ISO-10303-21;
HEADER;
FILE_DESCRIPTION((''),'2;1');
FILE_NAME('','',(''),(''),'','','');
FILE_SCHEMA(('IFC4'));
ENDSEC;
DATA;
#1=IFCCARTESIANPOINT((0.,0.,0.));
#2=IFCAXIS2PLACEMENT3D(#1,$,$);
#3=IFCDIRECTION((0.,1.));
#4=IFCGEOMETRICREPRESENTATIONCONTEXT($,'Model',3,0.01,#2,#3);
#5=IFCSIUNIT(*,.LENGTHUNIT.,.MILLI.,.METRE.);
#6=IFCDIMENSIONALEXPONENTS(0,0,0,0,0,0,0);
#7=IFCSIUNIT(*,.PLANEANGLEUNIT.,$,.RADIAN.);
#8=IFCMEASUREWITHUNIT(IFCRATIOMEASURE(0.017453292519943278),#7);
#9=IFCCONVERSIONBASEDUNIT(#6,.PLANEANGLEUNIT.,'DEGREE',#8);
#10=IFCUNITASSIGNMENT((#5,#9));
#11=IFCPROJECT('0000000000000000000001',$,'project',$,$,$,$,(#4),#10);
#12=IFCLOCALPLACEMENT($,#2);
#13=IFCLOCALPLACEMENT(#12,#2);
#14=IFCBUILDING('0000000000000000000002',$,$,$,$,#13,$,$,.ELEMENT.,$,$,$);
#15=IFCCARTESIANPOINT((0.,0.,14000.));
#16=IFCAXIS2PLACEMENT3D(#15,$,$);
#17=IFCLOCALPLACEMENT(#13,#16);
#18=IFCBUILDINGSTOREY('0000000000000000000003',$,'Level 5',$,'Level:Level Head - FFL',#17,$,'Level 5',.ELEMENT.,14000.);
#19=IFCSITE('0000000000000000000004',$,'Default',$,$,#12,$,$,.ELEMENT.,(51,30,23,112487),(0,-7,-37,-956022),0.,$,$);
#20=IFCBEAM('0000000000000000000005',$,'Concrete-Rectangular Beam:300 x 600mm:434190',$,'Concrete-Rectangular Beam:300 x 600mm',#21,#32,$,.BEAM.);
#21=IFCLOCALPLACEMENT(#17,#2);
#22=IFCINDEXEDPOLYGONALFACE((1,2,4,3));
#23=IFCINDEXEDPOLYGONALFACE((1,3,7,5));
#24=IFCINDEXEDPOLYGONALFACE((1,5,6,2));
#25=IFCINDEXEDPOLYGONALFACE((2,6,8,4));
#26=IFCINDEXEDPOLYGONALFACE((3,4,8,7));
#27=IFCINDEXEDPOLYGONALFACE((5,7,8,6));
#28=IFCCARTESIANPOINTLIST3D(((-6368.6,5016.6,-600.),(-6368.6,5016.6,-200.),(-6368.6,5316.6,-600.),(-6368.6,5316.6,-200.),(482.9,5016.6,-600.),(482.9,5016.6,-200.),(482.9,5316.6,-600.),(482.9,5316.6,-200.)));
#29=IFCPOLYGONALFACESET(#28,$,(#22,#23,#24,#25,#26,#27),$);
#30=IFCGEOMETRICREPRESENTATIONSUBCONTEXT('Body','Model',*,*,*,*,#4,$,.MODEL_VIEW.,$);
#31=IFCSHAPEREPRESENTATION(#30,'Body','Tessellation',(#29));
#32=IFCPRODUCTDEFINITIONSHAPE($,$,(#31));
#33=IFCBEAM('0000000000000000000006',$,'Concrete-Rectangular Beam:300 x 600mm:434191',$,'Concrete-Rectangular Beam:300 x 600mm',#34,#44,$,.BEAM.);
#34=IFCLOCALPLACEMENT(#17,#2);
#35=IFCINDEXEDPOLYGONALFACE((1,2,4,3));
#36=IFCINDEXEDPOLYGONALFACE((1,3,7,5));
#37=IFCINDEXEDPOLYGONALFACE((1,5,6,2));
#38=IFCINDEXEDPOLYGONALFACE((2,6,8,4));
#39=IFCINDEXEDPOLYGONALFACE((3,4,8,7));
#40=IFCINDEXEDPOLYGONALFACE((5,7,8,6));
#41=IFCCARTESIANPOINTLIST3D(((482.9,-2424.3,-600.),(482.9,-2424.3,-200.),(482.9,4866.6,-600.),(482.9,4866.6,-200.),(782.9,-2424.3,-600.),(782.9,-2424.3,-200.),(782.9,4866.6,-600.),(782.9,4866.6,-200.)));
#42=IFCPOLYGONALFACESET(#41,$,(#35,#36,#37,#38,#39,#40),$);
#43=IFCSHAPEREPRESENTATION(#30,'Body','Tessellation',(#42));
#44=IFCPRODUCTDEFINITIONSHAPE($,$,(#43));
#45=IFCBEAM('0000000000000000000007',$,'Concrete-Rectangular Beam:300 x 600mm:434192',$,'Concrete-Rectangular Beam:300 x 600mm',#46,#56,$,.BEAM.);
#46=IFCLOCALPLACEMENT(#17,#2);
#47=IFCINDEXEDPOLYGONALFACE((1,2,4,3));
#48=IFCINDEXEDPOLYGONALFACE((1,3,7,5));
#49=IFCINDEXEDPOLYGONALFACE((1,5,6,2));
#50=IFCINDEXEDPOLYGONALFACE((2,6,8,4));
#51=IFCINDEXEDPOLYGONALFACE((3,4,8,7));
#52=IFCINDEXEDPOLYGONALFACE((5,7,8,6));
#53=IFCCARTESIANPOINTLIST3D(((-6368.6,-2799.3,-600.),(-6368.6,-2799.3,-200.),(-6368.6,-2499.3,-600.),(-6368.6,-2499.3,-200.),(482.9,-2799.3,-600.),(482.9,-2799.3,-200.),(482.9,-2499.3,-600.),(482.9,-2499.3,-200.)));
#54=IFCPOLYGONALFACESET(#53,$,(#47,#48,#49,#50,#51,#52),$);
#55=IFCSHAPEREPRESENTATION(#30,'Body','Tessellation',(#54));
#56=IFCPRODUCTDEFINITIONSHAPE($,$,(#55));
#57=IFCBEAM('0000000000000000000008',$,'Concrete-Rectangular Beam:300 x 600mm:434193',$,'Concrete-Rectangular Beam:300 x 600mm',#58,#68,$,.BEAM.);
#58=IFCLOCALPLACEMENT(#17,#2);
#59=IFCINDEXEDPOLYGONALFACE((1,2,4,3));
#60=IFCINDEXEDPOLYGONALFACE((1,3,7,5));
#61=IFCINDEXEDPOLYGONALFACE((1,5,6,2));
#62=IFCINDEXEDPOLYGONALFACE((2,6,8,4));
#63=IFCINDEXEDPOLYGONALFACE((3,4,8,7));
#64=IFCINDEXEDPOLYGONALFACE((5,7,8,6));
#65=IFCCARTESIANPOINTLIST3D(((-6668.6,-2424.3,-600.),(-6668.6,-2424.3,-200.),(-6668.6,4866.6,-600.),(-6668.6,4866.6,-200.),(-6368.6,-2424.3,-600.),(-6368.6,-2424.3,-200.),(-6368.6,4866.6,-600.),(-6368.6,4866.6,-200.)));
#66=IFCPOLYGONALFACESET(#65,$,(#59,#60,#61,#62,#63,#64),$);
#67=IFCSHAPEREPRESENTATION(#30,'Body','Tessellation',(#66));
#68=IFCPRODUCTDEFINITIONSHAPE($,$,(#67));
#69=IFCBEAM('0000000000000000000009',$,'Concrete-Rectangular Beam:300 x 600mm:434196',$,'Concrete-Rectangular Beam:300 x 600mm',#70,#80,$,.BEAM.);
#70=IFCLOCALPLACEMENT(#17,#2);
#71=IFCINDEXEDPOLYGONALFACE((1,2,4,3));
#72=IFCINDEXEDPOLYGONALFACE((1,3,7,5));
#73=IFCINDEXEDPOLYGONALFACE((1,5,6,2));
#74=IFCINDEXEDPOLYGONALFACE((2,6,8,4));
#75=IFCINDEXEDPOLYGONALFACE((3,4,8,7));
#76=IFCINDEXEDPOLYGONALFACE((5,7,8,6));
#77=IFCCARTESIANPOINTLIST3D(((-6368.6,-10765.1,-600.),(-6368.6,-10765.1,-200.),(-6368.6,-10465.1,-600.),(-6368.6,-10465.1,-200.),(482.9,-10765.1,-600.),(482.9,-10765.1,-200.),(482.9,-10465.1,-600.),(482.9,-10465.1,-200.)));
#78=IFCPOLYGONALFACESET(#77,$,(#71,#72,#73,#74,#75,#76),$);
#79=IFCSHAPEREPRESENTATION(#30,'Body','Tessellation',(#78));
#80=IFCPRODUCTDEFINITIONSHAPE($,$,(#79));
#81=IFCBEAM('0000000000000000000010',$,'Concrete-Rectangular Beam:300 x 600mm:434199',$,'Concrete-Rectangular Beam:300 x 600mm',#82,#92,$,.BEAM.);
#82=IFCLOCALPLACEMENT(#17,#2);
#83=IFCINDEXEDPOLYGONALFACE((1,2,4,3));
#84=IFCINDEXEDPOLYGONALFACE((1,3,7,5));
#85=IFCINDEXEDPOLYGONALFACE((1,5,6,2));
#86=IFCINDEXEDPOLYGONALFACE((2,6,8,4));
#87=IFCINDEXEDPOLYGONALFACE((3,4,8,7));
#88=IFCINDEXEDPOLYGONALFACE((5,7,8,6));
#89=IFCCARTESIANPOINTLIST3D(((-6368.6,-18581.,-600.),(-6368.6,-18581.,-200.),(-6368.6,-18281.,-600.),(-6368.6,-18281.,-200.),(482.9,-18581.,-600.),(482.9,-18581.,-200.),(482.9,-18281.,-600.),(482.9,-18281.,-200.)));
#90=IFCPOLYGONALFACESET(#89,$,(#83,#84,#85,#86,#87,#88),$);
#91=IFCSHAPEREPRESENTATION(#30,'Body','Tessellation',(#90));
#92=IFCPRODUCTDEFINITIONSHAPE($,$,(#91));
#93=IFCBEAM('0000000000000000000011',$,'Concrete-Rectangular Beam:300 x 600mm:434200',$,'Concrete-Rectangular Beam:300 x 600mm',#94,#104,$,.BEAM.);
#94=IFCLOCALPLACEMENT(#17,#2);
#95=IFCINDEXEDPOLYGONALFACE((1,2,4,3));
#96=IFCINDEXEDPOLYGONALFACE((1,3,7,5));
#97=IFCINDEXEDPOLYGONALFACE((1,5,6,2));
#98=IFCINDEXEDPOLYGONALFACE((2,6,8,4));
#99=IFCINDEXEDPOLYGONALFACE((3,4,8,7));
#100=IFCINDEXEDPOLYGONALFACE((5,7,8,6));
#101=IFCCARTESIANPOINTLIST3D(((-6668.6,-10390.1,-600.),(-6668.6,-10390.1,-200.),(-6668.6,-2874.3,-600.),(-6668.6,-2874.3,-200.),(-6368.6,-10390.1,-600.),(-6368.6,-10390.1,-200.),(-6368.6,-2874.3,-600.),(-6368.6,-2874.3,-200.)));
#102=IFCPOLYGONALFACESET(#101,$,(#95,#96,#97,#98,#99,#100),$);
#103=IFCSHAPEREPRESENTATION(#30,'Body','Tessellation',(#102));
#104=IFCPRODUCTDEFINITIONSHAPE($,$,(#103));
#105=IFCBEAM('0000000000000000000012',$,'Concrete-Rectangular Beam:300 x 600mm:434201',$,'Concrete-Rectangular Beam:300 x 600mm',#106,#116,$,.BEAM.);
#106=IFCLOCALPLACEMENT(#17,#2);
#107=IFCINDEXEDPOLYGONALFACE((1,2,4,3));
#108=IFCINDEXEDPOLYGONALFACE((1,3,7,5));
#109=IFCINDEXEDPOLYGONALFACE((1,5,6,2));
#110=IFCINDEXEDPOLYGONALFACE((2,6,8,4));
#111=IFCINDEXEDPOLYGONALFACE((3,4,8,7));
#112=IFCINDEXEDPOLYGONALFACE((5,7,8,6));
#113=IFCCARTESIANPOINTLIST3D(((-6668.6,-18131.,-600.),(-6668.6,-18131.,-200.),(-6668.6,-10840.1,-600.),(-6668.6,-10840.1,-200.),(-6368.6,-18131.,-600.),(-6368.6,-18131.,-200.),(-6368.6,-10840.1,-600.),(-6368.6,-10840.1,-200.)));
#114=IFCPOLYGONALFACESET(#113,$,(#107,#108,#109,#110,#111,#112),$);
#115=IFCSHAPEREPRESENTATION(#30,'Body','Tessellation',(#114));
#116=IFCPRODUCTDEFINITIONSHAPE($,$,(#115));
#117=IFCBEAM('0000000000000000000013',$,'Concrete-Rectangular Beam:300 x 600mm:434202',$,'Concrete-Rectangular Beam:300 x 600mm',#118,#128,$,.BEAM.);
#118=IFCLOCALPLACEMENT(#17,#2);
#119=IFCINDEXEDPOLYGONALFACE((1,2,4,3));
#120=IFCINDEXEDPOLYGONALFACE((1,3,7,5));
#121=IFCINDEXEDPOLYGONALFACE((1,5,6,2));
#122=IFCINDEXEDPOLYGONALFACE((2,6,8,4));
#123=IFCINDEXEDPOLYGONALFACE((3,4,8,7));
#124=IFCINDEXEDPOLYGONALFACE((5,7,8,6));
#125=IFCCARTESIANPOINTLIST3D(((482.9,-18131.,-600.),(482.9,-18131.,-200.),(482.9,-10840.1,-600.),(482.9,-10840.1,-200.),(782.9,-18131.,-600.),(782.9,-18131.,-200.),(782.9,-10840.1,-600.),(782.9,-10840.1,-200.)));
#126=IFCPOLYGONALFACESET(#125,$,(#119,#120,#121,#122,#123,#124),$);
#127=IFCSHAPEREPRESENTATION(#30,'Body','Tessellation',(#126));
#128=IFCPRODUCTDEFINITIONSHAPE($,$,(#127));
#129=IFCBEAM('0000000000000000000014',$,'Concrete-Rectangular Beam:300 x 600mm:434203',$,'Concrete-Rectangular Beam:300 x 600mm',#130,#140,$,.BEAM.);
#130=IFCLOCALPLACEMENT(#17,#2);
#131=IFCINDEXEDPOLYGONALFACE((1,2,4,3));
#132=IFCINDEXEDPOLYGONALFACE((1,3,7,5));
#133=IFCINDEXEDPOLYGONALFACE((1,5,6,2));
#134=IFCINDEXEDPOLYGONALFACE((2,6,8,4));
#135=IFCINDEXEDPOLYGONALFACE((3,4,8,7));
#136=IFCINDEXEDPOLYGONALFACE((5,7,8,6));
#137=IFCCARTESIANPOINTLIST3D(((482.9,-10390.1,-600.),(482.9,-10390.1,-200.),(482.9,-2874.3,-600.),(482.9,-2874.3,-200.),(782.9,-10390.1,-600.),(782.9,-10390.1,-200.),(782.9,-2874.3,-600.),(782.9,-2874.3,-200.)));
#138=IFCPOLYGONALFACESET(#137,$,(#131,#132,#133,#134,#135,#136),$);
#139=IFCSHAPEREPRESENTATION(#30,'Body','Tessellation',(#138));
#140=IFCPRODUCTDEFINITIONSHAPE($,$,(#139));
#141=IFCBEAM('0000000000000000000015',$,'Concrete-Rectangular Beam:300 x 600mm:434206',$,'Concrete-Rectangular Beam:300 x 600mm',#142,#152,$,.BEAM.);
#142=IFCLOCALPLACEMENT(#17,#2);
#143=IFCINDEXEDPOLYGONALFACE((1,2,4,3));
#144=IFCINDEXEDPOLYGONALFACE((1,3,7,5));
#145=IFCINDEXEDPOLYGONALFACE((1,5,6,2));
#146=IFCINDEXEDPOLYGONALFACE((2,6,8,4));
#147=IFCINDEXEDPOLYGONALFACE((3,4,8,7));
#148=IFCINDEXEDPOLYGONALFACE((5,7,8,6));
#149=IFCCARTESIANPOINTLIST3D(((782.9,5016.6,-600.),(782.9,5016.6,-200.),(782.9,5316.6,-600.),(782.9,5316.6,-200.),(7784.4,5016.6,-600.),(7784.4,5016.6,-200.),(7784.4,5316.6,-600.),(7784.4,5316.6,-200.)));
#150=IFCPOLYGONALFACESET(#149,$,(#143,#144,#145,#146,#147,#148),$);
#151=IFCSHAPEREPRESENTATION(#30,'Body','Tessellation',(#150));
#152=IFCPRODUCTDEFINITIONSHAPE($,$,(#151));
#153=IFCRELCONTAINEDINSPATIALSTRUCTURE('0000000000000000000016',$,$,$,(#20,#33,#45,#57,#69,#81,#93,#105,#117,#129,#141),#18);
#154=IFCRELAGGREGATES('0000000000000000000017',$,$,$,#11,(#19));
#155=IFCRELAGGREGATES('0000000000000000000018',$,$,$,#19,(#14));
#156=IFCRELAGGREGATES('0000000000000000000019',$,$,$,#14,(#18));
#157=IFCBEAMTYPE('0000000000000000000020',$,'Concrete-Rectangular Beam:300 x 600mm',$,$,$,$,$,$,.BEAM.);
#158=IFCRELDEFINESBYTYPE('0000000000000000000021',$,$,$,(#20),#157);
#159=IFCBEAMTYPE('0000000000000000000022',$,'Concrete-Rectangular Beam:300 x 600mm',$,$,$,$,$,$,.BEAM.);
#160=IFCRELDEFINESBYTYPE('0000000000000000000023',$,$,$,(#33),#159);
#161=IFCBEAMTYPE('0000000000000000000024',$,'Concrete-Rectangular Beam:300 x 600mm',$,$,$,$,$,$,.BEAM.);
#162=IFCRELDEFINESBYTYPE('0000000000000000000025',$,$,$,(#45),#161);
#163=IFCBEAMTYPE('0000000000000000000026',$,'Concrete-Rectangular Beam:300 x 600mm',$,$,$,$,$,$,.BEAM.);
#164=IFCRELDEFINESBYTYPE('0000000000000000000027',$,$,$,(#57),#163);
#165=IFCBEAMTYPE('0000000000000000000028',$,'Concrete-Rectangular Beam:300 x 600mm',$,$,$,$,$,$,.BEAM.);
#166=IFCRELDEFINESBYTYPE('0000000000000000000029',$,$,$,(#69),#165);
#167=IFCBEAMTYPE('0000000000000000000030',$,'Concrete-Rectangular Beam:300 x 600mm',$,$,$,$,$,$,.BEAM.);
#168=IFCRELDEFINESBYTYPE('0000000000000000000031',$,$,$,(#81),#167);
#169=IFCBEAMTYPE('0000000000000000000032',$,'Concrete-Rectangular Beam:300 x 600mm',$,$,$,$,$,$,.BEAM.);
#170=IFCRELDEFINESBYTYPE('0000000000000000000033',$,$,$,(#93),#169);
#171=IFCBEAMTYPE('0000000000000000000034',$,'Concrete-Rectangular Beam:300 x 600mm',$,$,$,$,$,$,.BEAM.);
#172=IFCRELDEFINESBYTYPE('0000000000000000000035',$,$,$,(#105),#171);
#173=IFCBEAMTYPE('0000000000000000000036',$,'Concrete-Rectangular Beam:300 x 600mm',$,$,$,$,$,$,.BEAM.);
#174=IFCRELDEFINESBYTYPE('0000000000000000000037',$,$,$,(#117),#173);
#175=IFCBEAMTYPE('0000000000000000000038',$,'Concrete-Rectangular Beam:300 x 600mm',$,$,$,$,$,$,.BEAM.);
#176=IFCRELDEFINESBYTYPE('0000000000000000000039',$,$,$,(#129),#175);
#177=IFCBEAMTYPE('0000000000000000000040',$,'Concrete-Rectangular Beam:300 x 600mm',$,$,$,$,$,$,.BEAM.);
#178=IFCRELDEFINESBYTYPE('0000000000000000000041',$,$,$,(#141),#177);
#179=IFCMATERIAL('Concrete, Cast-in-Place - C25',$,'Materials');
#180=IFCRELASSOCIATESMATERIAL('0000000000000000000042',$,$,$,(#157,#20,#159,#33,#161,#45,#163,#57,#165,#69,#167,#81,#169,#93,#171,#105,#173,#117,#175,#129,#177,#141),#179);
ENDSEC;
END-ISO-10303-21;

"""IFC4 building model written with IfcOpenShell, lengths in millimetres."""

from ifc_helpers import new_model, entity, si_unit, converted_unit, direction, frame, origin, place, context, subcontext, project, spatial, indexed_curve, outline, extrude, source, transform, mapped, material, type_object, type_shapes, element, save


model = new_model("IFC4")

# Units and contexts
model_context = context("Model", 3, precision=0.01, world=origin(), true_north=direction((0.0, 1.0)))
body_context = subcontext(model_context, "Body", "Model", "MODEL_VIEW")
ifc_project = project(units=[si_unit("LENGTHUNIT", "METRE", prefix="MILLI"), converted_unit("PLANEANGLEUNIT", "DEGREE", entity("IfcRatioMeasure", 0.017453292519943278), si_unit("PLANEANGLEUNIT", "RADIAN"), dimensions=[0, 0, 0, 0, 0, 0, 0])], contexts=[model_context])

# Site, building, storey
site_placement = place(None, origin())
site = spatial("IfcSite", under=ifc_project, at=site_placement, Name="Default", CompositionType="ELEMENT", RefLatitude=(51, 30, 23, 112487), RefLongitude=(0, -7, -37, -956022), RefElevation=0.0)
building_placement = place(site_placement, origin())
building = spatial("IfcBuilding", under=site, at=building_placement, CompositionType="ELEMENT")
storey_placement = place(building_placement, frame((0.0, 0.0, 14000.0)))
storey = spatial("IfcBuildingStorey", under=building, at=storey_placement, Name="Level 5", ObjectType="Level:Level Head - FFL", LongName="Level 5", CompositionType="ELEMENT", Elevation=14000.0)

# Beams
ifc_material = material(Name="Concrete, Cast-in-Place - C25", Category="Materials")
beam_type_1 = type_object("IfcBeamType", Name="Concrete-Rectangular Beam:300 x 600mm", PredefinedType="BEAM", material=ifc_material)
shared_shape_1 = source(origin(), body_context, "Body", "SweptSolid", [
    extrude(outline(indexed_curve([(-200.0, -150.0), (200.0, -150.0), (200.0, 150.0), (-200.0, 150.0), (-200.0, -150.0)], self_intersect=False)), frame((-6368.6, 5166.6, 13600.0), z_axis=(1.0, 0.0, 0.0), x_axis=(0.0, 0.0, -1.0)), (0.0, 0.0, 1.0), 6851.5),
])
type_shapes(beam_type_1, [shared_shape_1])
beam_1_placement = place(storey_placement, frame((0.0, 0.0, -14000.0)))
element("IfcBeam", 1, at=beam_1_placement, inside=storey, type_object=beam_type_1, material=ifc_material, Name="Concrete-Rectangular Beam:300 x 600mm:434190", ObjectType="Concrete-Rectangular Beam:300 x 600mm", PredefinedType="BEAM", context=body_context, shape_type="MappedRepresentation", body=[
    mapped(shared_shape_1, transform((0.0, 0.0, 0.0), scale=1.0)),
])
beam_type_2 = type_object("IfcBeamType", Name="Concrete-Rectangular Beam:300 x 600mm", PredefinedType="BEAM", material=ifc_material)
shared_shape_2 = source(origin(), body_context, "Body", "SweptSolid", [
    extrude(outline(indexed_curve([(-150.0, -200.0), (150.0, -200.0), (150.0, 200.0), (-150.0, 200.0), (-150.0, -200.0)], self_intersect=False)), frame((632.9, 4866.6, 13600.0), z_axis=(0.0, -1.0, 0.0), x_axis=(-1.0, 0.0, 0.0)), (0.0, 0.0, 1.0), 7290.9),
])
type_shapes(beam_type_2, [shared_shape_2])
beam_2_placement = place(storey_placement, frame((0.0, 0.0, -14000.0)))
element("IfcBeam", 2, at=beam_2_placement, inside=storey, type_object=beam_type_2, material=ifc_material, Name="Concrete-Rectangular Beam:300 x 600mm:434191", ObjectType="Concrete-Rectangular Beam:300 x 600mm", PredefinedType="BEAM", context=body_context, shape_type="MappedRepresentation", body=[
    mapped(shared_shape_2, transform((0.0, 0.0, 0.0), scale=1.0)),
])
beam_type_3 = type_object("IfcBeamType", Name="Concrete-Rectangular Beam:300 x 600mm", PredefinedType="BEAM", material=ifc_material)
shared_shape_3 = source(origin(), body_context, "Body", "SweptSolid", [
    extrude(outline(indexed_curve([(-200.0, -150.0), (200.0, -150.0), (200.0, 150.0), (-200.0, 150.0), (-200.0, -150.0)], self_intersect=False)), frame((482.9, -2649.3, 13600.0), z_axis=(-1.0, 0.0, 0.0), x_axis=(0.0, 0.0, -1.0)), (0.0, 0.0, 1.0), 6851.5),
])
type_shapes(beam_type_3, [shared_shape_3])
beam_3_placement = place(storey_placement, frame((0.0, 0.0, -14000.0)))
element("IfcBeam", 3, at=beam_3_placement, inside=storey, type_object=beam_type_3, material=ifc_material, Name="Concrete-Rectangular Beam:300 x 600mm:434192", ObjectType="Concrete-Rectangular Beam:300 x 600mm", PredefinedType="BEAM", context=body_context, shape_type="MappedRepresentation", body=[
    mapped(shared_shape_3, transform((0.0, 0.0, 0.0), scale=1.0)),
])
beam_type_4 = type_object("IfcBeamType", Name="Concrete-Rectangular Beam:300 x 600mm", PredefinedType="BEAM", material=ifc_material)
shared_shape_4 = source(origin(), body_context, "Body", "SweptSolid", [
    extrude(outline(indexed_curve([(-150.0, -200.0), (150.0, -200.0), (150.0, 200.0), (-150.0, 200.0), (-150.0, -200.0)], self_intersect=False)), frame((-6518.6, -2424.3, 13600.0), z_axis=(0.0, 1.0, 0.0), x_axis=(-1.0, 0.0, 0.0)), (0.0, 0.0, 1.0), 7290.9),
])
type_shapes(beam_type_4, [shared_shape_4])
beam_4_placement = place(storey_placement, frame((0.0, 0.0, -14000.0)))
element("IfcBeam", 4, at=beam_4_placement, inside=storey, type_object=beam_type_4, material=ifc_material, Name="Concrete-Rectangular Beam:300 x 600mm:434193", ObjectType="Concrete-Rectangular Beam:300 x 600mm", PredefinedType="BEAM", context=body_context, shape_type="MappedRepresentation", body=[
    mapped(shared_shape_4, transform((0.0, 0.0, 0.0), scale=1.0)),
])
beam_type_5 = type_object("IfcBeamType", Name="Concrete-Rectangular Beam:300 x 600mm", PredefinedType="BEAM", material=ifc_material)
shared_shape_5 = source(origin(), body_context, "Body", "SweptSolid", [
    extrude(outline(indexed_curve([(-200.0, -150.0), (200.0, -150.0), (200.0, 150.0), (-200.0, 150.0), (-200.0, -150.0)], self_intersect=False)), frame((482.9, -10615.1, 13600.0), z_axis=(-1.0, 0.0, 0.0), x_axis=(0.0, 0.0, -1.0)), (0.0, 0.0, 1.0), 6851.5),
])
type_shapes(beam_type_5, [shared_shape_5])
beam_5_placement = place(storey_placement, frame((0.0, 0.0, -14000.0)))
element("IfcBeam", 5, at=beam_5_placement, inside=storey, type_object=beam_type_5, material=ifc_material, Name="Concrete-Rectangular Beam:300 x 600mm:434196", ObjectType="Concrete-Rectangular Beam:300 x 600mm", PredefinedType="BEAM", context=body_context, shape_type="MappedRepresentation", body=[
    mapped(shared_shape_5, transform((0.0, 0.0, 0.0), scale=1.0)),
])
beam_type_6 = type_object("IfcBeamType", Name="Concrete-Rectangular Beam:300 x 600mm", PredefinedType="BEAM", material=ifc_material)
shared_shape_6 = source(origin(), body_context, "Body", "SweptSolid", [
    extrude(outline(indexed_curve([(-200.0, -150.0), (200.0, -150.0), (200.0, 150.0), (-200.0, 150.0), (-200.0, -150.0)], self_intersect=False)), frame((482.9, -18431.0, 13600.0), z_axis=(-1.0, 0.0, 0.0), x_axis=(0.0, 0.0, -1.0)), (0.0, 0.0, 1.0), 6851.5),
])
type_shapes(beam_type_6, [shared_shape_6])
beam_6_placement = place(storey_placement, frame((0.0, 0.0, -14000.0)))
element("IfcBeam", 6, at=beam_6_placement, inside=storey, type_object=beam_type_6, material=ifc_material, Name="Concrete-Rectangular Beam:300 x 600mm:434199", ObjectType="Concrete-Rectangular Beam:300 x 600mm", PredefinedType="BEAM", context=body_context, shape_type="MappedRepresentation", body=[
    mapped(shared_shape_6, transform((0.0, 0.0, 0.0), scale=1.0)),
])
beam_type_7 = type_object("IfcBeamType", Name="Concrete-Rectangular Beam:300 x 600mm", PredefinedType="BEAM", material=ifc_material)
shared_shape_7 = source(origin(), body_context, "Body", "SweptSolid", [
    extrude(outline(indexed_curve([(-150.0, -200.0), (150.0, -200.0), (150.0, 200.0), (-150.0, 200.0), (-150.0, -200.0)], self_intersect=False)), frame((-6518.6, -2874.3, 13600.0), z_axis=(0.0, -1.0, 0.0), x_axis=(-1.0, 0.0, 0.0)), (0.0, 0.0, 1.0), 7515.9),
])
type_shapes(beam_type_7, [shared_shape_7])
beam_7_placement = place(storey_placement, frame((0.0, 0.0, -14000.0)))
element("IfcBeam", 7, at=beam_7_placement, inside=storey, type_object=beam_type_7, material=ifc_material, Name="Concrete-Rectangular Beam:300 x 600mm:434200", ObjectType="Concrete-Rectangular Beam:300 x 600mm", PredefinedType="BEAM", context=body_context, shape_type="MappedRepresentation", body=[
    mapped(shared_shape_7, transform((0.0, 0.0, 0.0), scale=1.0)),
])
beam_type_8 = type_object("IfcBeamType", Name="Concrete-Rectangular Beam:300 x 600mm", PredefinedType="BEAM", material=ifc_material)
shared_shape_8 = source(origin(), body_context, "Body", "SweptSolid", [
    extrude(outline(indexed_curve([(-150.0, -200.0), (150.0, -200.0), (150.0, 200.0), (-150.0, 200.0), (-150.0, -200.0)], self_intersect=False)), frame((-6518.6, -10840.1, 13600.0), z_axis=(0.0, -1.0, 0.0), x_axis=(-1.0, 0.0, 0.0)), (0.0, 0.0, 1.0), 7290.9),
])
type_shapes(beam_type_8, [shared_shape_8])
beam_8_placement = place(storey_placement, frame((0.0, 0.0, -14000.0)))
element("IfcBeam", 8, at=beam_8_placement, inside=storey, type_object=beam_type_8, material=ifc_material, Name="Concrete-Rectangular Beam:300 x 600mm:434201", ObjectType="Concrete-Rectangular Beam:300 x 600mm", PredefinedType="BEAM", context=body_context, shape_type="MappedRepresentation", body=[
    mapped(shared_shape_8, transform((0.0, 0.0, 0.0), scale=1.0)),
])
beam_type_9 = type_object("IfcBeamType", Name="Concrete-Rectangular Beam:300 x 600mm", PredefinedType="BEAM", material=ifc_material)
shared_shape_9 = source(origin(), body_context, "Body", "SweptSolid", [
    extrude(outline(indexed_curve([(-150.0, -200.0), (150.0, -200.0), (150.0, 200.0), (-150.0, 200.0), (-150.0, -200.0)], self_intersect=False)), frame((632.9, -18131.0, 13600.0), z_axis=(0.0, 1.0, 0.0), x_axis=(-1.0, 0.0, 0.0)), (0.0, 0.0, 1.0), 7290.9),
])
type_shapes(beam_type_9, [shared_shape_9])
beam_9_placement = place(storey_placement, frame((0.0, 0.0, -14000.0)))
element("IfcBeam", 9, at=beam_9_placement, inside=storey, type_object=beam_type_9, material=ifc_material, Name="Concrete-Rectangular Beam:300 x 600mm:434202", ObjectType="Concrete-Rectangular Beam:300 x 600mm", PredefinedType="BEAM", context=body_context, shape_type="MappedRepresentation", body=[
    mapped(shared_shape_9, transform((0.0, 0.0, 0.0), scale=1.0)),
])
beam_type_10 = type_object("IfcBeamType", Name="Concrete-Rectangular Beam:300 x 600mm", PredefinedType="BEAM", material=ifc_material)
shared_shape_10 = source(origin(), body_context, "Body", "SweptSolid", [
    extrude(outline(indexed_curve([(-150.0, -200.0), (150.0, -200.0), (150.0, 200.0), (-150.0, 200.0), (-150.0, -200.0)], self_intersect=False)), frame((632.9, -10390.1, 13600.0), z_axis=(0.0, 1.0, 0.0), x_axis=(-1.0, 0.0, 0.0)), (0.0, 0.0, 1.0), 7515.9),
])
type_shapes(beam_type_10, [shared_shape_10])
beam_10_placement = place(storey_placement, frame((0.0, 0.0, -14000.0)))
element("IfcBeam", 10, at=beam_10_placement, inside=storey, type_object=beam_type_10, material=ifc_material, Name="Concrete-Rectangular Beam:300 x 600mm:434203", ObjectType="Concrete-Rectangular Beam:300 x 600mm", PredefinedType="BEAM", context=body_context, shape_type="MappedRepresentation", body=[
    mapped(shared_shape_10, transform((0.0, 0.0, 0.0), scale=1.0)),
])
beam_type_11 = type_object("IfcBeamType", Name="Concrete-Rectangular Beam:300 x 600mm", PredefinedType="BEAM", material=ifc_material)
shared_shape_11 = source(origin(), body_context, "Body", "SweptSolid", [
    extrude(outline(indexed_curve([(-200.0, -150.0), (200.0, -150.0), (200.0, 150.0), (-200.0, 150.0), (-200.0, -150.0)], self_intersect=False)), frame((782.9, 5166.6, 13600.0), z_axis=(1.0, 0.0, 0.0), x_axis=(0.0, 0.0, -1.0)), (0.0, 0.0, 1.0), 7001.5),
])
type_shapes(beam_type_11, [shared_shape_11])
beam_11_placement = place(storey_placement, frame((0.0, 0.0, -14000.0)))
element("IfcBeam", 11, at=beam_11_placement, inside=storey, type_object=beam_type_11, material=ifc_material, Name="Concrete-Rectangular Beam:300 x 600mm:434206", ObjectType="Concrete-Rectangular Beam:300 x 600mm", PredefinedType="BEAM", context=body_context, shape_type="MappedRepresentation", body=[
    mapped(shared_shape_11, transform((0.0, 0.0, 0.0), scale=1.0)),
])

save(model, "model.ifc")
